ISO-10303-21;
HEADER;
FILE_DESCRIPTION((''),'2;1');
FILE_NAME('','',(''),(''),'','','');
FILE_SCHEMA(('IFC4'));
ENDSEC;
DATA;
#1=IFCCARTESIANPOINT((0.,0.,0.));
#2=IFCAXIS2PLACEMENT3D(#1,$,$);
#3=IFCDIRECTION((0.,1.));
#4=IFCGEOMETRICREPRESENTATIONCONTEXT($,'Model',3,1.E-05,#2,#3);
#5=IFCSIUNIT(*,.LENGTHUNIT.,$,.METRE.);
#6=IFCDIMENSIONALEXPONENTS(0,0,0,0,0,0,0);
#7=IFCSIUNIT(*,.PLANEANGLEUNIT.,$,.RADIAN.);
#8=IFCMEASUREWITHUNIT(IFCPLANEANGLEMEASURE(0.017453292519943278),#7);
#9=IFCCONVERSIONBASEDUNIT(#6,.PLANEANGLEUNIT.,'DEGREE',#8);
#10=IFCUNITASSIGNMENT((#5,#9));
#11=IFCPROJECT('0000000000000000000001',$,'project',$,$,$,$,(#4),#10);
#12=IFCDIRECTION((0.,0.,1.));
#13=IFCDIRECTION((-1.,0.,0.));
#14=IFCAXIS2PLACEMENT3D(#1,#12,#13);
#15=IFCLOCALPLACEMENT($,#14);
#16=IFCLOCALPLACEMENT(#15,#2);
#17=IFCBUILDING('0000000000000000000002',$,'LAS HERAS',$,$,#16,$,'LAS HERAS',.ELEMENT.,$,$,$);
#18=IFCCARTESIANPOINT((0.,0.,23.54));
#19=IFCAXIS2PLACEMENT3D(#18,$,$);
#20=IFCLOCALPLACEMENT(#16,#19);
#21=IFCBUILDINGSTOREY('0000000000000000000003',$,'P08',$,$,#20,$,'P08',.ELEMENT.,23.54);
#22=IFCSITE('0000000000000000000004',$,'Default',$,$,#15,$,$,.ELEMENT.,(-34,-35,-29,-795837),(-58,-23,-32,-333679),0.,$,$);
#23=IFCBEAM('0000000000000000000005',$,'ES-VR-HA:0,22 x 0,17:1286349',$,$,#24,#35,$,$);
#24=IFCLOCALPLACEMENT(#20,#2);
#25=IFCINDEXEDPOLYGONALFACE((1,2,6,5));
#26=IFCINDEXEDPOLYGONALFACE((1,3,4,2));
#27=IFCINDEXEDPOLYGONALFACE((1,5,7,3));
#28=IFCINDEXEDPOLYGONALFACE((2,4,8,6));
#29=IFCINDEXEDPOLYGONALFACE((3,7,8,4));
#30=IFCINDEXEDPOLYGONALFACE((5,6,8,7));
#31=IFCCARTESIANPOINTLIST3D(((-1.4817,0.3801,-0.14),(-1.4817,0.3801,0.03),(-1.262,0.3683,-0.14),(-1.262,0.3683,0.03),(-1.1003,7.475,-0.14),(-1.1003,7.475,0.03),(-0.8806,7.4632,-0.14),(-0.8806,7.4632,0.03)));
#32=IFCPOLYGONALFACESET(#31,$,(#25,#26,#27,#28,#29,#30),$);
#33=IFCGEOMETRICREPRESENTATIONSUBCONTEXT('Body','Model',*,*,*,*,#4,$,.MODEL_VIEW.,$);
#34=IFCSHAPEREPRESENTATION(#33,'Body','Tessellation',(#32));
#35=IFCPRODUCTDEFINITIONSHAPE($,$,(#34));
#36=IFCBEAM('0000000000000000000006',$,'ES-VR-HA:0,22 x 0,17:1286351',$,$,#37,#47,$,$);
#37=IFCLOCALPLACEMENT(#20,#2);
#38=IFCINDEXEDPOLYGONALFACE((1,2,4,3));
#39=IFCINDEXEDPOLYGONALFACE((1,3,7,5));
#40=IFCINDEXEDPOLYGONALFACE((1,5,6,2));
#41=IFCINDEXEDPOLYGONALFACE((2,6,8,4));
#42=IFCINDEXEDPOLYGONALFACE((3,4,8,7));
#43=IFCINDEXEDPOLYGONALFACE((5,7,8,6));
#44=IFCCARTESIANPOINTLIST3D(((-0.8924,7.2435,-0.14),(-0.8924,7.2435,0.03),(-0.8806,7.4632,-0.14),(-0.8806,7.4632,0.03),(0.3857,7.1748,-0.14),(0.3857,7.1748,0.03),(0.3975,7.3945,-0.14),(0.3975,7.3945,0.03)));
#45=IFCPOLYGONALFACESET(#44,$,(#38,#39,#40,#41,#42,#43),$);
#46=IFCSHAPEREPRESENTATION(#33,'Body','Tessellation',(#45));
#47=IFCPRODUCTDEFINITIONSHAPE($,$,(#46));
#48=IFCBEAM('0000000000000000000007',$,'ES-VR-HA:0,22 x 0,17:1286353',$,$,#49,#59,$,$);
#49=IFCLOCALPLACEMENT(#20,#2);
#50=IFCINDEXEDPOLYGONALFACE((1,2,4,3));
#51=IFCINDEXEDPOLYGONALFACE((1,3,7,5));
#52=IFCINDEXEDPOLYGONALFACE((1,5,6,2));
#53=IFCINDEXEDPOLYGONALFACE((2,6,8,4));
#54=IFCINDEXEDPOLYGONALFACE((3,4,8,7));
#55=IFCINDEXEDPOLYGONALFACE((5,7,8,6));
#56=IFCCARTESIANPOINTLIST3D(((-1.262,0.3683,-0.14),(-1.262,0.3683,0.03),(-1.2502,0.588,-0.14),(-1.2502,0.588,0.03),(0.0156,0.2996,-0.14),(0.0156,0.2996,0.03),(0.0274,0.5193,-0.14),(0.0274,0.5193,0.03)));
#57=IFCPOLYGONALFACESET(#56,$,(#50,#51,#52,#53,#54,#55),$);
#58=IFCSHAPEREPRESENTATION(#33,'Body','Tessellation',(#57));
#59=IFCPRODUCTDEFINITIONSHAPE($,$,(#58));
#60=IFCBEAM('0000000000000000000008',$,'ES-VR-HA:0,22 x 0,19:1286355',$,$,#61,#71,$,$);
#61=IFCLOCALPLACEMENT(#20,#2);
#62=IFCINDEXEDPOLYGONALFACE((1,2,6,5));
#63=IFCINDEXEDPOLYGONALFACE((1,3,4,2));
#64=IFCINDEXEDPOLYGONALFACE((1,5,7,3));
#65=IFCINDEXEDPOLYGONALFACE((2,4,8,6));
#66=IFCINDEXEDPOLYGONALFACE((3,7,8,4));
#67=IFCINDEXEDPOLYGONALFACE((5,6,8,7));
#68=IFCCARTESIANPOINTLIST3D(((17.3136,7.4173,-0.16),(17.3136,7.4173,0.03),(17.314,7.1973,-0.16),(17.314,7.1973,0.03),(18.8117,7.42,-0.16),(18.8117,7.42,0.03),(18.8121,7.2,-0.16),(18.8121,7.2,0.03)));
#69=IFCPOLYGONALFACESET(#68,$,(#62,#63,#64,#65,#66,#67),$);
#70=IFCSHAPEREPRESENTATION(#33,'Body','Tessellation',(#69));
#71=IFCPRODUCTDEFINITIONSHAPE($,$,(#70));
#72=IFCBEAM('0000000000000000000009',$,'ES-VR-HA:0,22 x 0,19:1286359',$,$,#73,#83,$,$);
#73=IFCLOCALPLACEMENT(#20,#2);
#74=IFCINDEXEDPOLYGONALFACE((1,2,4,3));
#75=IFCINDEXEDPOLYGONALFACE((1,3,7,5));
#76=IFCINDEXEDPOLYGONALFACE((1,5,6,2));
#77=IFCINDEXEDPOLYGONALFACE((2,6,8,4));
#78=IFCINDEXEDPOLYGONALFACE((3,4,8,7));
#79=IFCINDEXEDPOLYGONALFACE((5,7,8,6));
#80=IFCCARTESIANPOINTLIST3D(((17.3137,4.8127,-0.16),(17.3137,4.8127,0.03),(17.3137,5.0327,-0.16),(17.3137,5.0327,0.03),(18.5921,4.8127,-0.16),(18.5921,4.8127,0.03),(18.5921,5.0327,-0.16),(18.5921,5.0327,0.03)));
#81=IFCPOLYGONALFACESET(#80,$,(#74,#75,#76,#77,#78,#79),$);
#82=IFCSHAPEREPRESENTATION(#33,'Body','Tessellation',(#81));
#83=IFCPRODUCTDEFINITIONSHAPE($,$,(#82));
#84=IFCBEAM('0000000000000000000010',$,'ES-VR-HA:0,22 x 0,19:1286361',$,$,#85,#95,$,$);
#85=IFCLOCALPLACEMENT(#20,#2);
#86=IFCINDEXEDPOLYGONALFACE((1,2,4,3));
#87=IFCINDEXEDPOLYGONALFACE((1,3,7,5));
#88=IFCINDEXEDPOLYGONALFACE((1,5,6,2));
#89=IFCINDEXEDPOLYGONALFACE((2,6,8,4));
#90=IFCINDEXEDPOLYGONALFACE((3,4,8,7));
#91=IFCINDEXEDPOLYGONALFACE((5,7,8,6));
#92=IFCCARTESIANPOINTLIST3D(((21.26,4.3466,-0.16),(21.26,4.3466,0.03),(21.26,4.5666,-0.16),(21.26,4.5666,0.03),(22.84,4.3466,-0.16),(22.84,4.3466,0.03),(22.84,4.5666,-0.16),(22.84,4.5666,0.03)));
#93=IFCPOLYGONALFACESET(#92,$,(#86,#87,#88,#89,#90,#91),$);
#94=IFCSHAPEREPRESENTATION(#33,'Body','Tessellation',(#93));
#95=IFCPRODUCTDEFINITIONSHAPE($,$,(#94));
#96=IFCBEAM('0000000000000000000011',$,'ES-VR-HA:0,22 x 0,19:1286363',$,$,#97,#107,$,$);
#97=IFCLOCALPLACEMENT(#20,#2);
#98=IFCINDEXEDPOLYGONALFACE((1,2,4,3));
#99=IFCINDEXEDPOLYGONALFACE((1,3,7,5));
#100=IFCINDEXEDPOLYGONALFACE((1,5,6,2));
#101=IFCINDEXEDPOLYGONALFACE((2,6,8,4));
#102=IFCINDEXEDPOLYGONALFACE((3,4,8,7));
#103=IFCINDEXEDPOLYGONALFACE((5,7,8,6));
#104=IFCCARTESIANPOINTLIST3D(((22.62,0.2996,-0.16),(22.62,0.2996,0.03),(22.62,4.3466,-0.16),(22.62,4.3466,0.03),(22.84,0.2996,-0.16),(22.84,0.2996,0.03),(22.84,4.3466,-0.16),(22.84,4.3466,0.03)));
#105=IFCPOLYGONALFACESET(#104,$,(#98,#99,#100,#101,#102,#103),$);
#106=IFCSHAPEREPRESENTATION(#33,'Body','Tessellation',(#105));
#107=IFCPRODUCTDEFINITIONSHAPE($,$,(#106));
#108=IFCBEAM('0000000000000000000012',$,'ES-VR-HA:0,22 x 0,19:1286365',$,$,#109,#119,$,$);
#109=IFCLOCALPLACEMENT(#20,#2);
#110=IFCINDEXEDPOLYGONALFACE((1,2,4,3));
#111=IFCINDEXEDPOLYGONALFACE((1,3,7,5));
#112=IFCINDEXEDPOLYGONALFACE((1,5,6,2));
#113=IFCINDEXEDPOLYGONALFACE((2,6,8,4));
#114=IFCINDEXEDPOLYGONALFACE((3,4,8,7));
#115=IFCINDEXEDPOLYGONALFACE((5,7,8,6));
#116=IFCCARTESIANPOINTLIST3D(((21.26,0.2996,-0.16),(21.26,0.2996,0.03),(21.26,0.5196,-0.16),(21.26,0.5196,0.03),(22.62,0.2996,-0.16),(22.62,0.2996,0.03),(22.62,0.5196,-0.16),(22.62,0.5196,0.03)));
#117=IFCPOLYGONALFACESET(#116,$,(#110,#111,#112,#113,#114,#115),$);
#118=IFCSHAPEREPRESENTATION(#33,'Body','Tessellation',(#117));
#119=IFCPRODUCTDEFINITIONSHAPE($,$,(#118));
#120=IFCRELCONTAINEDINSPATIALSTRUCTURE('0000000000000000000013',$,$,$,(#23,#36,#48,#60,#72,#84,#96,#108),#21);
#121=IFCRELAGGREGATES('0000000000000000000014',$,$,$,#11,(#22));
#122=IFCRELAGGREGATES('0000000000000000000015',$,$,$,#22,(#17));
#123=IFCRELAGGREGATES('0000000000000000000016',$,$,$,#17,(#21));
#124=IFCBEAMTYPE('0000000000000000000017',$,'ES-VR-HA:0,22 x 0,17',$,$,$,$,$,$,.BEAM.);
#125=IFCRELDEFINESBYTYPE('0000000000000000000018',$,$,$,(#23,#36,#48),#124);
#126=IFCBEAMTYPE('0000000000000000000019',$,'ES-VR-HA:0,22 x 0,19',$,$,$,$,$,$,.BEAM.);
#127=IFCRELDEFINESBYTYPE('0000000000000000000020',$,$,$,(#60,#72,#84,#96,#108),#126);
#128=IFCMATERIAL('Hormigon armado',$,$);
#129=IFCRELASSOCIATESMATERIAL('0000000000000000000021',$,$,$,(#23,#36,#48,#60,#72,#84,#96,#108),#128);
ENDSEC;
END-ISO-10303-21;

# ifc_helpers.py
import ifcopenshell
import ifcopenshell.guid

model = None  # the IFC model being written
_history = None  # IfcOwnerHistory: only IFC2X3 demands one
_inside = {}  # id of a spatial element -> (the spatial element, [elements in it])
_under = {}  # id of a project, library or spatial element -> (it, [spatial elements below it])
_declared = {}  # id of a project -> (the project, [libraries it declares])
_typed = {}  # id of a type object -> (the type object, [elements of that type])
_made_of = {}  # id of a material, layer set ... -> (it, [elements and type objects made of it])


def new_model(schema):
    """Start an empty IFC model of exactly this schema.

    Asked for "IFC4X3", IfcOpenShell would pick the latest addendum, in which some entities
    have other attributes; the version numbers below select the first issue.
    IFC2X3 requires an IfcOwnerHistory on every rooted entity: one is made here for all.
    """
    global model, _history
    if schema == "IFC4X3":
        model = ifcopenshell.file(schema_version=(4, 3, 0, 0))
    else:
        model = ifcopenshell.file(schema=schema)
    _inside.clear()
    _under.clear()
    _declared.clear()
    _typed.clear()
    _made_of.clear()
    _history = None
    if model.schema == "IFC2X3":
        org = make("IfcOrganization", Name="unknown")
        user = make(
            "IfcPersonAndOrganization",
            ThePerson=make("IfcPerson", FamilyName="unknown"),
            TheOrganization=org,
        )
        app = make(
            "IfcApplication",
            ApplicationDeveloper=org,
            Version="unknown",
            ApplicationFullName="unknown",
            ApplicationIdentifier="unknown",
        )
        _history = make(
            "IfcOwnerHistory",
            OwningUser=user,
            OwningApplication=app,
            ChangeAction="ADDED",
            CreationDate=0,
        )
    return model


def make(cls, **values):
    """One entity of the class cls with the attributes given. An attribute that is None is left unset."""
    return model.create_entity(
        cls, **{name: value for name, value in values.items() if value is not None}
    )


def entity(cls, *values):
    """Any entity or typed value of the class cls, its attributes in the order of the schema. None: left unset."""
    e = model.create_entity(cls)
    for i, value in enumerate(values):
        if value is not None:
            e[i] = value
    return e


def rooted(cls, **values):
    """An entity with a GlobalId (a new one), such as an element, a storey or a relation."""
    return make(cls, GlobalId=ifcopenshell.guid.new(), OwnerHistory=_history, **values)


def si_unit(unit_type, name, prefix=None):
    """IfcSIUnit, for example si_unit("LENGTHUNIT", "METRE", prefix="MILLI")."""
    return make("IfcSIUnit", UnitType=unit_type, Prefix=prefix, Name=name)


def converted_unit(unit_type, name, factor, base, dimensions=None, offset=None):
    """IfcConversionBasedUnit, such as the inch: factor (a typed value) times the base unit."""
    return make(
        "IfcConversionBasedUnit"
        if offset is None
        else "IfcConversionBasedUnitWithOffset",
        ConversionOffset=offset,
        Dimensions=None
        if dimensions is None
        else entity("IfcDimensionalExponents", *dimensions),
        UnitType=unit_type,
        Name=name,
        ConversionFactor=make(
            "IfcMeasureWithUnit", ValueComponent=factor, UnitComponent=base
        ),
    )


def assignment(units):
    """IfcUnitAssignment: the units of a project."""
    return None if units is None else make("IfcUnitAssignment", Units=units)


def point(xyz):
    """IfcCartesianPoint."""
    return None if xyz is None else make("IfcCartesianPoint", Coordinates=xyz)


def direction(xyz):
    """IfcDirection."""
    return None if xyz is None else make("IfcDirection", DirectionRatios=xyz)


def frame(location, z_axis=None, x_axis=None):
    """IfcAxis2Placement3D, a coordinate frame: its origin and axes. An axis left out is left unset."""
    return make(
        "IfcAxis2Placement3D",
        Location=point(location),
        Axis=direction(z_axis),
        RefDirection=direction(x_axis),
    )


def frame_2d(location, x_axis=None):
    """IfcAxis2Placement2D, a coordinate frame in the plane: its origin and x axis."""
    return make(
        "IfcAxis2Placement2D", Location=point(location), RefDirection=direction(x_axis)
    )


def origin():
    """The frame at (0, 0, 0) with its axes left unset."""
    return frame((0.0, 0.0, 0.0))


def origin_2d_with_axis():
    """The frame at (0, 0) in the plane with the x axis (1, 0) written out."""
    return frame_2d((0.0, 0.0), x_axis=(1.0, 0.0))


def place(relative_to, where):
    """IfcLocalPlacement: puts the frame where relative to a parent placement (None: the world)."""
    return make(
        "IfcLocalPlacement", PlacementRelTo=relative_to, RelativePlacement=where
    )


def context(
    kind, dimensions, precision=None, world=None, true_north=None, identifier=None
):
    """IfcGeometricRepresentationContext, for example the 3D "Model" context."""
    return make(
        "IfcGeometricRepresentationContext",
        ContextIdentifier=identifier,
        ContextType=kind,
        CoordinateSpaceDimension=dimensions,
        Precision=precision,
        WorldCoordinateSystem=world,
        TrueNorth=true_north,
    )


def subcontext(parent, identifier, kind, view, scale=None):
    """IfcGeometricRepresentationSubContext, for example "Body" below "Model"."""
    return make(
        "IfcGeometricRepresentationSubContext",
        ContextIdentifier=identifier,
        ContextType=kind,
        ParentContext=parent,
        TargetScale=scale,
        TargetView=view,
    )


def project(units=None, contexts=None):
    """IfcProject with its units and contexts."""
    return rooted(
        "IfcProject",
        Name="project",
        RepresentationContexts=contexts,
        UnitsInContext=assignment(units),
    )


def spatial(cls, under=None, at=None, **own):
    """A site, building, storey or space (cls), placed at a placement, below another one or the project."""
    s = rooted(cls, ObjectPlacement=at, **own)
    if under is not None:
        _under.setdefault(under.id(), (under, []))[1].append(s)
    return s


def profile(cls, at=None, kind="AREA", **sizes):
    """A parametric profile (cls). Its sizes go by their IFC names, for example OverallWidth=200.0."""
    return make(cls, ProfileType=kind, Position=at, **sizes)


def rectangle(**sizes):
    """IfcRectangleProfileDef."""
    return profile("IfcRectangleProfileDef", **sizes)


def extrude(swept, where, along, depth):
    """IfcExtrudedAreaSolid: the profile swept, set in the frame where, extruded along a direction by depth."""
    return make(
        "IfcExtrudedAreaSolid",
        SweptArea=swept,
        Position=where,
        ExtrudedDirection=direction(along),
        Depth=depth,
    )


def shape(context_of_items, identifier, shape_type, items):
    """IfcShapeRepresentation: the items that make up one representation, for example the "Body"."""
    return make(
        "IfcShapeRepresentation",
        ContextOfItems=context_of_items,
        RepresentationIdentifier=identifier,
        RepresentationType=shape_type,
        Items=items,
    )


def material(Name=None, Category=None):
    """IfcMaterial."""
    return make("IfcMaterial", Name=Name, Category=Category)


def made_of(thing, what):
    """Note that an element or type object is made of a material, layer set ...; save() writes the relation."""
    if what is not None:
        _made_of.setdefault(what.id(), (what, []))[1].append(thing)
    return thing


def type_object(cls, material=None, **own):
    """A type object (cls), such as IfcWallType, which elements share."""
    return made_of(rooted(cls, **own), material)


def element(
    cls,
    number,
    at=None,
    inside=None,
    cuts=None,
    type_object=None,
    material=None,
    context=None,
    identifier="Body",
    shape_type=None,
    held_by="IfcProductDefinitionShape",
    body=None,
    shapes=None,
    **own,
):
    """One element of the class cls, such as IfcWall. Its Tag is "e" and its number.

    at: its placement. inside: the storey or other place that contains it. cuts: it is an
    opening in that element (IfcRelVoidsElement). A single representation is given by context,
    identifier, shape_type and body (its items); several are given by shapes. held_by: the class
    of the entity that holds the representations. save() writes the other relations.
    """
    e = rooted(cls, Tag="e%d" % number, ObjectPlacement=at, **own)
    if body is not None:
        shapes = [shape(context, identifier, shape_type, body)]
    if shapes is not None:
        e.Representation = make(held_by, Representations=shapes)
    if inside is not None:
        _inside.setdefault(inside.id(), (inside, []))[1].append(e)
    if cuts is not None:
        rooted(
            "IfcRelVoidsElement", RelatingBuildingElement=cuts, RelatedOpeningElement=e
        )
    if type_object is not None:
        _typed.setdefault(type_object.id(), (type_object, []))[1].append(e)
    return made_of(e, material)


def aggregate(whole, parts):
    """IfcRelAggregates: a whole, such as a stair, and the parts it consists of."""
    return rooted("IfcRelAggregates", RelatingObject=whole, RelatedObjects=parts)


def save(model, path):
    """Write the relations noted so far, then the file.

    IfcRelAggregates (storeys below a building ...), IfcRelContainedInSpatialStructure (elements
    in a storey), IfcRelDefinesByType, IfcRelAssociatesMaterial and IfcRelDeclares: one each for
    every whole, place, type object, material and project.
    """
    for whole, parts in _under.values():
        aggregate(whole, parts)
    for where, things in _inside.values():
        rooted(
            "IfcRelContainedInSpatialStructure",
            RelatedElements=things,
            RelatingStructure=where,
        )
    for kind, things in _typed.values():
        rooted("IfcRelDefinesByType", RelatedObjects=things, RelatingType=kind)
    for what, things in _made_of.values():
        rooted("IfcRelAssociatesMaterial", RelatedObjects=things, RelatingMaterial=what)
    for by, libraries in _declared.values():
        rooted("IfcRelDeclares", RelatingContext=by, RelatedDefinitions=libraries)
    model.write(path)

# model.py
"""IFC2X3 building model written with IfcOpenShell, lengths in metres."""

from ifc_helpers import new_model, entity, si_unit, converted_unit, direction, frame, frame_2d, origin, origin_2d_with_axis, place, context, subcontext, project, spatial, rectangle, extrude, material, type_object, element, save


model = new_model("IFC2X3")

# Units and contexts
model_context = context("Model", 3, precision=1e-05, world=origin(), true_north=direction((0.0, 1.0)))
body_context = subcontext(model_context, "Body", "Model", "MODEL_VIEW")
ifc_project = project(units=[si_unit("LENGTHUNIT", "METRE"), converted_unit("PLANEANGLEUNIT", "DEGREE", entity("IfcPlaneAngleMeasure", 0.017453292519943278), si_unit("PLANEANGLEUNIT", "RADIAN"), dimensions=[0, 0, 0, 0, 0, 0, 0])], contexts=[model_context])

# Site, building, storey
site_placement = place(None, frame((0.0, 0.0, 0.0), z_axis=(0.0, 0.0, 1.0), x_axis=(-1.0, 0.0, 0.0)))
site = spatial("IfcSite", under=ifc_project, at=site_placement, Name="Default", CompositionType="ELEMENT", RefLatitude=(-34, -35, -29, -795837), RefLongitude=(-58, -23, -32, -333679), RefElevation=0.0)
building_placement = place(site_placement, origin())
building = spatial("IfcBuilding", under=site, at=building_placement, Name="LAS HERAS", LongName="LAS HERAS", CompositionType="ELEMENT")
storey_placement = place(building_placement, frame((0.0, 0.0, 23.54)))
storey = spatial("IfcBuildingStorey", under=building, at=storey_placement, Name="P08", LongName="P08", CompositionType="ELEMENT", Elevation=23.54)

# Beams
ifc_material = material(Name="Hormigon armado")
beam_type_1 = type_object("IfcBeamType", Name="ES-VR-HA:0,22 x 0,17", PredefinedType="BEAM")
beam_1_placement = place(storey_placement, frame((-0.9963, 7.3593, 0.03), z_axis=(0.0, 0.0, 1.0), x_axis=(-0.05369, -0.998558, 0.0)))
element("IfcBeam", 1, at=beam_1_placement, inside=storey, type_object=beam_type_1, material=ifc_material, Name="ES-VR-HA:0,22 x 0,17:1286349", context=body_context, shape_type="SweptSolid", body=[
    extrude(rectangle(XDim=0.17, YDim=0.22, at=frame_2d((0.0, 0.0), x_axis=(1.0, 0.0))), frame((-0.11, 0.0, -0.085), z_axis=(1.0, 0.0, 0.0), x_axis=(0.0, 0.0, -1.0)), (0.0, 0.0, 1.0), 7.1052),
])
beam_2_placement = place(storey_placement, frame((0.3916, 7.2846, 0.03), z_axis=(0.0, 0.0, 1.0), x_axis=(-0.998558, 0.05368, 0.0)))
element("IfcBeam", 2, at=beam_2_placement, inside=storey, type_object=beam_type_1, material=ifc_material, Name="ES-VR-HA:0,22 x 0,17:1286351", context=body_context, shape_type="SweptSolid", body=[
    extrude(rectangle(XDim=0.17, YDim=0.22, at=frame_2d((0.0, 0.0), x_axis=(1.0, 0.0))), frame((0.0, 0.0, -0.085), z_axis=(1.0, 0.0, 0.0), x_axis=(0.0, 0.0, -1.0)), (0.0, 0.0, 1.0), 1.28),
])
beam_3_placement = place(storey_placement, frame((0.0215, 0.4094, 0.03), z_axis=(0.0, 0.0, 1.0), x_axis=(-0.998558, 0.05369, 0.0)))
element("IfcBeam", 3, at=beam_3_placement, inside=storey, type_object=beam_type_1, material=ifc_material, Name="ES-VR-HA:0,22 x 0,17:1286353", context=body_context, shape_type="SweptSolid", body=[
    extrude(rectangle(XDim=0.17, YDim=0.22, at=frame_2d((0.0, 0.0), x_axis=(1.0, 0.0))), frame((0.0, 0.0, -0.085), z_axis=(1.0, 0.0, 0.0), x_axis=(0.0, 0.0, -1.0)), (0.0, 0.0, 1.0), 1.2795),
])
beam_type_2 = type_object("IfcBeamType", Name="ES-VR-HA:0,22 x 0,19", PredefinedType="BEAM")
beam_4_placement = place(storey_placement, frame((17.3138, 7.3073, 0.03), z_axis=(0.0, 0.0, 1.0), x_axis=(0.999998, 0.001781, 0.0)))
element("IfcBeam", 4, at=beam_4_placement, inside=storey, type_object=beam_type_2, material=ifc_material, Name="ES-VR-HA:0,22 x 0,19:1286355", context=body_context, shape_type="SweptSolid", body=[
    extrude(rectangle(XDim=0.19, YDim=0.22, at=frame_2d((0.0, 0.0), x_axis=(1.0, 0.0))), frame((0.0, 0.0, -0.095), z_axis=(1.0, 0.0, 0.0), x_axis=(0.0, 0.0, -1.0)), (0.0, 0.0, 1.0), 1.4981),
])
beam_5_placement = place(storey_placement, frame((17.3137, 4.9227, 0.03)))
element("IfcBeam", 5, at=beam_5_placement, inside=storey, type_object=beam_type_2, material=ifc_material, Name="ES-VR-HA:0,22 x 0,19:1286359", context=body_context, shape_type="SweptSolid", body=[
    extrude(rectangle(XDim=0.19, YDim=0.22, at=frame_2d((0.0, 0.0), x_axis=(1.0, 0.0))), frame((0.0, 0.0, -0.095), z_axis=(1.0, 0.0, 0.0), x_axis=(0.0, 0.0, -1.0)), (0.0, 0.0, 1.0), 1.2784),
])
beam_6_placement = place(storey_placement, frame((21.26, 4.4566, 0.03)))
element("IfcBeam", 6, at=beam_6_placement, inside=storey, type_object=beam_type_2, material=ifc_material, Name="ES-VR-HA:0,22 x 0,19:1286361", context=body_context, shape_type="SweptSolid", body=[
    extrude(rectangle(XDim=0.19, YDim=0.22, at=origin_2d_with_axis()), frame((0.0, 0.0, -0.095), z_axis=(1.0, 0.0, 0.0), x_axis=(0.0, 0.0, -1.0)), (0.0, 0.0, 1.0), 1.58),
])
beam_7_placement = place(storey_placement, frame((22.73, 4.4566, 0.03), z_axis=(0.0, 0.0, 1.0), x_axis=(0.0, -1.0, 0.0)))
element("IfcBeam", 7, at=beam_7_placement, inside=storey, type_object=beam_type_2, material=ifc_material, Name="ES-VR-HA:0,22 x 0,19:1286363", context=body_context, shape_type="SweptSolid", body=[
    extrude(rectangle(XDim=0.19, YDim=0.22, at=frame_2d((0.0, 0.0), x_axis=(1.0, 0.0))), frame((0.11, 0.0, -0.095), z_axis=(1.0, 0.0, 0.0), x_axis=(0.0, 0.0, -1.0)), (0.0, 0.0, 1.0), 4.0471),
])
beam_8_placement = place(storey_placement, frame((21.26, 0.4096, 0.03)))
element("IfcBeam", 8, at=beam_8_placement, inside=storey, type_object=beam_type_2, material=ifc_material, Name="ES-VR-HA:0,22 x 0,19:1286365", context=body_context, shape_type="SweptSolid", body=[
    extrude(rectangle(XDim=0.19, YDim=0.22, at=frame_2d((0.0, 0.0), x_axis=(1.0, 0.0))), frame((0.0, 0.0, -0.095), z_axis=(1.0, 0.0, 0.0), x_axis=(0.0, 0.0, -1.0)), (0.0, 0.0, 1.0), 1.36),
])

save(model, "model.ifc")
